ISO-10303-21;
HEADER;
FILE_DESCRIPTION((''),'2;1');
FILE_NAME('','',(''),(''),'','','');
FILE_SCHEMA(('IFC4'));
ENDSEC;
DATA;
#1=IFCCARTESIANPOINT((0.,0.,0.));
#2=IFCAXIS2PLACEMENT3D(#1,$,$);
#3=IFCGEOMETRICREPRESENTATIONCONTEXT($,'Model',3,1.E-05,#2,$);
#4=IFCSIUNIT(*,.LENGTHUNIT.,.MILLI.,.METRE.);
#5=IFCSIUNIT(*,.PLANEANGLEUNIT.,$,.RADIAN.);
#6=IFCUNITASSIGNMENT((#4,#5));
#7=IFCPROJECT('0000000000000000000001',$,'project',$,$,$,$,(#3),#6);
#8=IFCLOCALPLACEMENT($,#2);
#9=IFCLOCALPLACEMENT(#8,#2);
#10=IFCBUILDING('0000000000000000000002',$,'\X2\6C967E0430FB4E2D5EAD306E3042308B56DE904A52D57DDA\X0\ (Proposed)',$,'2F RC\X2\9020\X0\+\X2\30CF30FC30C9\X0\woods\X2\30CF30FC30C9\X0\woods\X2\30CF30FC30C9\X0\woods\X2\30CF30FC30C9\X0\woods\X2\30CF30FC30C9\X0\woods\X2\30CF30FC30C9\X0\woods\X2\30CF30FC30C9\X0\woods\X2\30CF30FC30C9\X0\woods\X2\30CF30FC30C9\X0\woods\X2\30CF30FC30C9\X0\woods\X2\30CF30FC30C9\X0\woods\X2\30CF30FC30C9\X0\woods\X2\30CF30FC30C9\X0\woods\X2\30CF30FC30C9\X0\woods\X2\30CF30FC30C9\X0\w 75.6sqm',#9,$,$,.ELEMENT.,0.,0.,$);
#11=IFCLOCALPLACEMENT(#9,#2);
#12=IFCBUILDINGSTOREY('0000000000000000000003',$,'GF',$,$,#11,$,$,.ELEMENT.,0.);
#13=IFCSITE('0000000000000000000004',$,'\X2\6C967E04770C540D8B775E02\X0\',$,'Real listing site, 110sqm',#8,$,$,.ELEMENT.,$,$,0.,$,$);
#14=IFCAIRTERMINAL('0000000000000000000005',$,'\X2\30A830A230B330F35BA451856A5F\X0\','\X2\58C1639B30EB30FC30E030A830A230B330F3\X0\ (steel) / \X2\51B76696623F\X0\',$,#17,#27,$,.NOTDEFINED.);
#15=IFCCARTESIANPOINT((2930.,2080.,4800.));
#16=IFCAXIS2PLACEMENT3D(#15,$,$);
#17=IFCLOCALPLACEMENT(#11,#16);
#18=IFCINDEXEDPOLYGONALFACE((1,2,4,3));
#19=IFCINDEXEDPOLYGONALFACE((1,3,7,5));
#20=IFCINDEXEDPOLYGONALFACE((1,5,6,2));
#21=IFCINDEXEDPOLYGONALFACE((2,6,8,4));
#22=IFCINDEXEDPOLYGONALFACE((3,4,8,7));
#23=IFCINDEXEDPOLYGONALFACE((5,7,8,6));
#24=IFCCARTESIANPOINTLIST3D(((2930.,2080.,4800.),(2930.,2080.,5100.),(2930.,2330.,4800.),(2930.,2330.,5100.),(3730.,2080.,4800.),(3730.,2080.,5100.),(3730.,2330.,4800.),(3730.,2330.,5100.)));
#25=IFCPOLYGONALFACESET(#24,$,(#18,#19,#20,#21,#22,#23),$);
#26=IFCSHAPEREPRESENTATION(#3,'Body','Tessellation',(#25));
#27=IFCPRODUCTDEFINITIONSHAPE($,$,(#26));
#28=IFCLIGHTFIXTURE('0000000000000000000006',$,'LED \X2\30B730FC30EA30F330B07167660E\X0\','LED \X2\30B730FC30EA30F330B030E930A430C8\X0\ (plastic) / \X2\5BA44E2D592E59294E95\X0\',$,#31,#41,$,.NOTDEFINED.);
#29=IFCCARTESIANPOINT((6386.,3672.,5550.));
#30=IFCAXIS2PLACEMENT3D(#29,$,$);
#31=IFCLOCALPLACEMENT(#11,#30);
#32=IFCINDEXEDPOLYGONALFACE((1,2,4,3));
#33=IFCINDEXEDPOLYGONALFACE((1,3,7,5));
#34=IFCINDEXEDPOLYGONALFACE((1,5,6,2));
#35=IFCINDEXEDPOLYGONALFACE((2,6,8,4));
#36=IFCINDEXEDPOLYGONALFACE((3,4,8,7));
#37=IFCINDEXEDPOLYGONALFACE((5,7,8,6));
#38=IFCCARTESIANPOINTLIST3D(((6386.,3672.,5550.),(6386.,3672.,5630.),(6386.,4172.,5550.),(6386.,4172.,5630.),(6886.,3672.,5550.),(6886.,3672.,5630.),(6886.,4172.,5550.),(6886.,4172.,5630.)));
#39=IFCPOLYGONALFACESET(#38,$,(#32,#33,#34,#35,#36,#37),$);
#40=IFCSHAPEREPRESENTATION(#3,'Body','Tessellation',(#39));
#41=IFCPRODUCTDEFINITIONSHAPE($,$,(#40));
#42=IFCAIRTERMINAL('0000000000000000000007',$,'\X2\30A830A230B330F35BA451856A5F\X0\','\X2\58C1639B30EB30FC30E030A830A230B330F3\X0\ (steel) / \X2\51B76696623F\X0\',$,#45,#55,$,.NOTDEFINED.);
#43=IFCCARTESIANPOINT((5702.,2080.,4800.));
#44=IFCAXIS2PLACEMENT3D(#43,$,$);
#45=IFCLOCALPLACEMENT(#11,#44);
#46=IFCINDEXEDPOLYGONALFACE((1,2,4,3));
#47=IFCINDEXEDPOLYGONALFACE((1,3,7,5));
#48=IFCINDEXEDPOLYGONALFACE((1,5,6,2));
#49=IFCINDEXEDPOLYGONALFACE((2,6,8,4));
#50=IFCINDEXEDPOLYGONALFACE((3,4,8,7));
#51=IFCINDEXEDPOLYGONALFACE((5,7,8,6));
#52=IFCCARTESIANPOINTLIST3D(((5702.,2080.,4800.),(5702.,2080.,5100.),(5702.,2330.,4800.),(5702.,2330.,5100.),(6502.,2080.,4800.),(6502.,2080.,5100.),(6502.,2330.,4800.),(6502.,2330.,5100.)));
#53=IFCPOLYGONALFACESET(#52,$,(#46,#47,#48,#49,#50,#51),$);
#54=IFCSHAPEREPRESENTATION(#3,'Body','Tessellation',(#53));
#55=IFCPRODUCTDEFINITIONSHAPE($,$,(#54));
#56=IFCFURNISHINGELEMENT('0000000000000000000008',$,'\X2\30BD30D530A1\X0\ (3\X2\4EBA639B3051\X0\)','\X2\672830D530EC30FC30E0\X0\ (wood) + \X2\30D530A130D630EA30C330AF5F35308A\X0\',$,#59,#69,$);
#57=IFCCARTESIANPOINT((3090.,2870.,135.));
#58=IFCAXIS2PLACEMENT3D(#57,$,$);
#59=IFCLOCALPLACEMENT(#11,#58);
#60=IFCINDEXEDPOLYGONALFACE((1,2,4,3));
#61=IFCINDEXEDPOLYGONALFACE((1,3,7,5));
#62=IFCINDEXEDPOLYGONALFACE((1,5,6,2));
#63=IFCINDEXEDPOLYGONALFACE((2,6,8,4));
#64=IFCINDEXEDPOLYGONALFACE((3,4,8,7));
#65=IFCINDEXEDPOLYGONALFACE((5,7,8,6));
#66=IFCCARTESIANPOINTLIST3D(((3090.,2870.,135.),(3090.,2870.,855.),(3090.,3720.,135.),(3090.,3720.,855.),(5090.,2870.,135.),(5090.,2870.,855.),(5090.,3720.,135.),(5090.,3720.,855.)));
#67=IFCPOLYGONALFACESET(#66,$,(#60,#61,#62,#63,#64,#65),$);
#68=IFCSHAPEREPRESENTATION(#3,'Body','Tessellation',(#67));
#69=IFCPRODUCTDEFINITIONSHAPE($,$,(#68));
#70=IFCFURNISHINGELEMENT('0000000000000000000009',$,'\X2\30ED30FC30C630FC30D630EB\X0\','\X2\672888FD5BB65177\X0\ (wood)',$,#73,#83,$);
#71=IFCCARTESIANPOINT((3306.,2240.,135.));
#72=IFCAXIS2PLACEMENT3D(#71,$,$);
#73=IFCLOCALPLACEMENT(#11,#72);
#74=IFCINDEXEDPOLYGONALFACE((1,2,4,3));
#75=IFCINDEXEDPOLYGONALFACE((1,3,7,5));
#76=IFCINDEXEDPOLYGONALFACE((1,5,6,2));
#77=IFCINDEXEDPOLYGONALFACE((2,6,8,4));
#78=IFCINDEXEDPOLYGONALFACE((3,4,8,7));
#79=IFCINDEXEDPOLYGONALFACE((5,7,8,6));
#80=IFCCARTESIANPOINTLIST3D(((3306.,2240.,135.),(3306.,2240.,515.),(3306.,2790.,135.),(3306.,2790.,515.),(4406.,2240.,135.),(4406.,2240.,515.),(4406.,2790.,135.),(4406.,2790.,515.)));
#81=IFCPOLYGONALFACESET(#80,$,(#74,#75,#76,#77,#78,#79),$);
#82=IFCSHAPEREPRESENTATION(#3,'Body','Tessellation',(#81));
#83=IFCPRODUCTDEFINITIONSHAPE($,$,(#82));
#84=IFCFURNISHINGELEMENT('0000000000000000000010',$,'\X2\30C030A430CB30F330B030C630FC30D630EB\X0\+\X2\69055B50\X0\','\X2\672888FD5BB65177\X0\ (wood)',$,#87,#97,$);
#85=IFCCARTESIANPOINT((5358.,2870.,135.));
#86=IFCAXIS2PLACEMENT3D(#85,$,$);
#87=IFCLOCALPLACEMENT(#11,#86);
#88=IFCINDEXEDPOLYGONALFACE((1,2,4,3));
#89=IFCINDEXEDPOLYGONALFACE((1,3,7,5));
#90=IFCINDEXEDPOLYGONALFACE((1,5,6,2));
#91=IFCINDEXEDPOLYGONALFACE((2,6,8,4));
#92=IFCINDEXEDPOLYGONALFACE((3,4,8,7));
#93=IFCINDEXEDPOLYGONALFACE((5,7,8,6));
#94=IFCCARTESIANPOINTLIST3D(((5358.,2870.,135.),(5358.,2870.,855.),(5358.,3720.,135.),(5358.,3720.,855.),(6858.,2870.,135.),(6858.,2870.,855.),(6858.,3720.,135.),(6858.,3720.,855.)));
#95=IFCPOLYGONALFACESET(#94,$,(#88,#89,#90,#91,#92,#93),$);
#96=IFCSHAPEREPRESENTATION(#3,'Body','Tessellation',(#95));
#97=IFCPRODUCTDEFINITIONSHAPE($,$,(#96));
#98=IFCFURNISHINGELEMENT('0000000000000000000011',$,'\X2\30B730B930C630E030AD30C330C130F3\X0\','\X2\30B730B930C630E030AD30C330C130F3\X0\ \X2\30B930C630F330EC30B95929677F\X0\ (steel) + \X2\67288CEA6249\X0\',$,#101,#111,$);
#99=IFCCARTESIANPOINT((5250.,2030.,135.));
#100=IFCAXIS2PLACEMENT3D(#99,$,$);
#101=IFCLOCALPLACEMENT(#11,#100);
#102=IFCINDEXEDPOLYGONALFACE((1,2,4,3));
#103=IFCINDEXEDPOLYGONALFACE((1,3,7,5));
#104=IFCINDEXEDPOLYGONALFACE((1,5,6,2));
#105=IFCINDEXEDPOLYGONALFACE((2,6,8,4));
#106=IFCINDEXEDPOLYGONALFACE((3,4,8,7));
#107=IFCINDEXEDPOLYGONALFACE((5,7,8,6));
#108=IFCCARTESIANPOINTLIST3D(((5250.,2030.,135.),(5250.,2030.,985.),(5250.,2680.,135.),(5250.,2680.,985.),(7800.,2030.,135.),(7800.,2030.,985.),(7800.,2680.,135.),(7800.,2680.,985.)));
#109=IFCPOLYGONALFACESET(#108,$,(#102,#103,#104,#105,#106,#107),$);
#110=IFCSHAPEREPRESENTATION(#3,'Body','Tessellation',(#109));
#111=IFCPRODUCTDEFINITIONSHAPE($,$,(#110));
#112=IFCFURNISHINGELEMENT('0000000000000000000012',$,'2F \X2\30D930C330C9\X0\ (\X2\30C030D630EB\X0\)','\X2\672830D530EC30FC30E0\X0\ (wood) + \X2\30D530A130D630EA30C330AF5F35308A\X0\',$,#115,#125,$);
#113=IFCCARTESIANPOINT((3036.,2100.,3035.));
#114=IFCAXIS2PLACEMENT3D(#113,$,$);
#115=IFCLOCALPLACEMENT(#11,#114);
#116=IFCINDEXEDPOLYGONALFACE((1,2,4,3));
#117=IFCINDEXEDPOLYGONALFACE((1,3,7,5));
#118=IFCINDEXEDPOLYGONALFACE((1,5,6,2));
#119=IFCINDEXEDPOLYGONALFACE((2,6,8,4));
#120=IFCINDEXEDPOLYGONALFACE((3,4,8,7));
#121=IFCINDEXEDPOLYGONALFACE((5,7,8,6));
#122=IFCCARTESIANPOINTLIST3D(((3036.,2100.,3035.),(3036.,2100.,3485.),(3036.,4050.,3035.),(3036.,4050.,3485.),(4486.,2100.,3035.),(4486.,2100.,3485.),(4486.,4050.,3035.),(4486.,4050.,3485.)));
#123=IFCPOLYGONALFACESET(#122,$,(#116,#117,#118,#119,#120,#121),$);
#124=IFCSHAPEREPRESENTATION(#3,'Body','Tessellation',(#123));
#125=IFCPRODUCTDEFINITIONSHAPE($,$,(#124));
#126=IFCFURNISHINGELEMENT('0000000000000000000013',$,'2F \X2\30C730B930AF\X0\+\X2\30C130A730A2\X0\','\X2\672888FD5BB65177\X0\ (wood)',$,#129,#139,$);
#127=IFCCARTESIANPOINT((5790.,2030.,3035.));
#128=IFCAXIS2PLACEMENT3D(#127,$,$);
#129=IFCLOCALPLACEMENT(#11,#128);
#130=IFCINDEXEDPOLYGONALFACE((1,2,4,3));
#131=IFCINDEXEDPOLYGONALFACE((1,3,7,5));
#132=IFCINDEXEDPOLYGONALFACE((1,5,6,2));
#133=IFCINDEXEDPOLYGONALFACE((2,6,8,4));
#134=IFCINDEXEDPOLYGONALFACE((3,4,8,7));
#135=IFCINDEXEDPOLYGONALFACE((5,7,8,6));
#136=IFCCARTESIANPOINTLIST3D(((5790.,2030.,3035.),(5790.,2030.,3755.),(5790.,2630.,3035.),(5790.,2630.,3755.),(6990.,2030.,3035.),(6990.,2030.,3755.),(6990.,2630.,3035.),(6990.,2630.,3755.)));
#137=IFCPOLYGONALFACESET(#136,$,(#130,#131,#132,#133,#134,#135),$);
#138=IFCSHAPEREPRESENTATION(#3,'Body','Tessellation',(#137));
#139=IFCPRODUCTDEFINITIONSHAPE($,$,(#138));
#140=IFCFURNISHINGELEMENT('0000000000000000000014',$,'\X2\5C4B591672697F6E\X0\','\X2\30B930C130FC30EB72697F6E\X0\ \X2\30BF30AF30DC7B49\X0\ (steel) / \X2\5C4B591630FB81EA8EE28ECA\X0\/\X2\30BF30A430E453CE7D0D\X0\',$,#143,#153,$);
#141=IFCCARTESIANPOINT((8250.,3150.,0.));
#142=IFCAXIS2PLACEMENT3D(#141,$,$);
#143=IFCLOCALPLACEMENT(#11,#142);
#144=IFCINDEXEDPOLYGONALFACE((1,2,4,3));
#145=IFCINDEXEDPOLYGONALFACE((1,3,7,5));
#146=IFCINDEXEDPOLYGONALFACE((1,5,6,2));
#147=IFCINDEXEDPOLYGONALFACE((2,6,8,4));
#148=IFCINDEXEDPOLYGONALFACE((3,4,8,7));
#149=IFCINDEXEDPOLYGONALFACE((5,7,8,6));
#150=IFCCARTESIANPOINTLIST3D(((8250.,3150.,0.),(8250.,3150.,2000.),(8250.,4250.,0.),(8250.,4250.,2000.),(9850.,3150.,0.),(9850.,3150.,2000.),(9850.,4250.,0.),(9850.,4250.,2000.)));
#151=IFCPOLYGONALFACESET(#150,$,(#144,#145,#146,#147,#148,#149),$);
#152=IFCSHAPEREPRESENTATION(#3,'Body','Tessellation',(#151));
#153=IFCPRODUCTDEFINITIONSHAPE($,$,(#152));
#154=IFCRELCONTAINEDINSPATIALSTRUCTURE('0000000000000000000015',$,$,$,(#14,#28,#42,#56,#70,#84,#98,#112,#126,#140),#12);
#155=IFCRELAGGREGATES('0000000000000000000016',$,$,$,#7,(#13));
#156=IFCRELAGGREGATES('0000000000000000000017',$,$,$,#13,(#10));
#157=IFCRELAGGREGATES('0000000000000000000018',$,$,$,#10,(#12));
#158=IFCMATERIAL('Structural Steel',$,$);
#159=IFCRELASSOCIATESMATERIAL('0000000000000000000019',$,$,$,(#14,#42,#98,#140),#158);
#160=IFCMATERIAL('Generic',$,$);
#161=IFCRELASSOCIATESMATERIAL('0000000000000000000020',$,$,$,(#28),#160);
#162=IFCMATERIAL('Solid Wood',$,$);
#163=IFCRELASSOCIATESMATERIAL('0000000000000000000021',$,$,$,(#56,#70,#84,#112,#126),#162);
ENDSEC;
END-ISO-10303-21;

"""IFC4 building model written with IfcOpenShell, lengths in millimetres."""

from ifc_helpers import new_model, si_unit, frame, frame_2d, origin, place, context, project, spatial, rectangle, extrude, material, element, save


model = new_model("IFC4")

# Units and contexts
model_context = context("Model", 3, precision=1e-05, world=origin())
ifc_project = project(units=[si_unit("LENGTHUNIT", "METRE", prefix="MILLI"), si_unit("PLANEANGLEUNIT", "RADIAN")], contexts=[model_context])

# Site, building, storey
site_placement = place(None, origin())
site = spatial("IfcSite", under=ifc_project, at=site_placement, Name="沖縄県名護市", ObjectType="Real listing site, 110sqm", CompositionType="ELEMENT", RefElevation=0.0)
building_placement = place(site_placement, origin())
building = spatial("IfcBuilding", under=site, at=building_placement, Name="沖縄・中庭のある回遊動線 (Proposed)", ObjectType="2F RC造+ハードwoodsハードwoodsハードwoodsハードwoodsハードwoodsハードwoodsハードwoodsハードwoodsハードwoodsハードwoodsハードwoodsハードwoodsハードwoodsハードwoodsハードw 75.6sqm", CompositionType="ELEMENT", ElevationOfRefHeight=0.0, ElevationOfTerrain=0.0)
storey_placement = place(building_placement, origin())
storey = spatial("IfcBuildingStorey", under=building, at=storey_placement, Name="GF", CompositionType="ELEMENT", Elevation=0.0)

# Shared definitions
ifc_material_1 = material(Name="Solid Wood")

# Shared definitions
ifc_material_2 = material(Name="Generic")

# Shared definitions
ifc_material_3 = material(Name="Structural Steel")

# Air terminal
air_terminal_1_placement = place(storey_placement, frame((2930.0, 2080.0, 4800.0)))
element("IfcAirTerminal", 1, at=air_terminal_1_placement, inside=storey, material=ifc_material_3, Name="エアコン室内機", Description="壁掛ルームエアコン (steel) / 冷暖房", PredefinedType="NOTDEFINED", context=model_context, shape_type="SweptSolid", body=[
    extrude(rectangle(XDim=800.0, YDim=250.0, at=frame_2d((400.0, 125.0))), frame((2930.0, 2080.0, 4800.0)), (0.0, 0.0, 1.0), 300.0),
])

# Light fixture
light_fixture_1_placement = place(storey_placement, frame((6386.0, 3672.0, 5550.0)))
element("IfcLightFixture", 2, at=light_fixture_1_placement, inside=storey, material=ifc_material_2, Name="LED シーリング照明", Description="LED シーリングライト (plastic) / 室中央天井", PredefinedType="NOTDEFINED", context=model_context, shape_type="SweptSolid", body=[
    extrude(rectangle(XDim=500.0, YDim=500.0, at=frame_2d((250.0, 250.0))), frame((6386.0, 3672.0, 5550.0)), (0.0, 0.0, 1.0), 80.0),
])

# Air terminal
air_terminal_2_placement = place(storey_placement, frame((5702.0, 2080.0, 4800.0)))
element("IfcAirTerminal", 3, at=air_terminal_2_placement, inside=storey, material=ifc_material_3, Name="エアコン室内機", Description="壁掛ルームエアコン (steel) / 冷暖房", PredefinedType="NOTDEFINED", context=model_context, shape_type="SweptSolid", body=[
    extrude(rectangle(XDim=800.0, YDim=250.0, at=frame_2d((400.0, 125.0))), frame((5702.0, 2080.0, 4800.0)), (0.0, 0.0, 1.0), 300.0),
])

# Furnishing elements
furnishing_1_placement = place(storey_placement, frame((3090.0, 2870.0, 135.0)))
element("IfcFurnishingElement", 4, at=furnishing_1_placement, inside=storey, material=ifc_material_1, Name="ソファ (3人掛け)", Description="木フレーム (wood) + ファブリック張り", context=model_context, shape_type="SweptSolid", body=[
    extrude(rectangle(XDim=2000.0, YDim=850.0, at=frame_2d((1000.0, 425.0))), frame((3090.0, 2870.0, 135.0)), (0.0, 0.0, 1.0), 720.0),
])
furnishing_2_placement = place(storey_placement, frame((3306.0, 2240.0, 135.0)))
element("IfcFurnishingElement", 5, at=furnishing_2_placement, inside=storey, material=ifc_material_1, Name="ローテーブル", Description="木製家具 (wood)", context=model_context, shape_type="SweptSolid", body=[
    extrude(rectangle(XDim=1100.0, YDim=550.0, at=frame_2d((550.0, 275.0))), frame((3306.0, 2240.0, 135.0)), (0.0, 0.0, 1.0), 380.0),
])
furnishing_3_placement = place(storey_placement, frame((5358.0, 2870.0, 135.0)))
element("IfcFurnishingElement", 6, at=furnishing_3_placement, inside=storey, material=ifc_material_1, Name="ダイニングテーブル+椅子", Description="木製家具 (wood)", context=model_context, shape_type="SweptSolid", body=[
    extrude(rectangle(XDim=1500.0, YDim=850.0, at=frame_2d((750.0, 425.0))), frame((5358.0, 2870.0, 135.0)), (0.0, 0.0, 1.0), 720.0),
])
furnishing_4_placement = place(storey_placement, frame((5250.0, 2030.0, 135.0)))
element("IfcFurnishingElement", 7, at=furnishing_4_placement, inside=storey, material=ifc_material_3, Name="システムキッチン", Description="システムキッチン ステンレス天板 (steel) + 木質扉", context=model_context, shape_type="SweptSolid", body=[
    extrude(rectangle(XDim=2550.0, YDim=650.0, at=frame_2d((1275.0, 325.0))), frame((5250.0, 2030.0, 135.0)), (0.0, 0.0, 1.0), 850.0),
])
furnishing_5_placement = place(storey_placement, frame((3036.0, 2100.0, 3035.0)))
element("IfcFurnishingElement", 8, at=furnishing_5_placement, inside=storey, material=ifc_material_1, Name="2F ベッド (ダブル)", Description="木フレーム (wood) + ファブリック張り", context=model_context, shape_type="SweptSolid", body=[
    extrude(rectangle(XDim=1450.0, YDim=1950.0, at=frame_2d((725.0, 975.0))), frame((3036.0, 2100.0, 3035.0)), (0.0, 0.0, 1.0), 450.0),
])
furnishing_6_placement = place(storey_placement, frame((5790.0, 2030.0, 3035.0)))
element("IfcFurnishingElement", 9, at=furnishing_6_placement, inside=storey, material=ifc_material_1, Name="2F デスク+チェア", Description="木製家具 (wood)", context=model_context, shape_type="SweptSolid", body=[
    extrude(rectangle(XDim=1200.0, YDim=600.0, at=frame_2d((600.0, 300.0))), frame((5790.0, 2030.0, 3035.0)), (0.0, 0.0, 1.0), 720.0),
])
furnishing_7_placement = place(storey_placement, frame((8250.0, 3150.0, 0.0)))
element("IfcFurnishingElement", 10, at=furnishing_7_placement, inside=storey, material=ifc_material_3, Name="屋外物置", Description="スチール物置 タクボ等 (steel) / 屋外・自転車/タイヤ収納", context=model_context, shape_type="SweptSolid", body=[
    extrude(rectangle(XDim=1600.0, YDim=1100.0, at=frame_2d((800.0, 550.0))), frame((8250.0, 3150.0, 0.0)), (0.0, 0.0, 1.0), 2000.0),
])

save(model, "model.ifc")
